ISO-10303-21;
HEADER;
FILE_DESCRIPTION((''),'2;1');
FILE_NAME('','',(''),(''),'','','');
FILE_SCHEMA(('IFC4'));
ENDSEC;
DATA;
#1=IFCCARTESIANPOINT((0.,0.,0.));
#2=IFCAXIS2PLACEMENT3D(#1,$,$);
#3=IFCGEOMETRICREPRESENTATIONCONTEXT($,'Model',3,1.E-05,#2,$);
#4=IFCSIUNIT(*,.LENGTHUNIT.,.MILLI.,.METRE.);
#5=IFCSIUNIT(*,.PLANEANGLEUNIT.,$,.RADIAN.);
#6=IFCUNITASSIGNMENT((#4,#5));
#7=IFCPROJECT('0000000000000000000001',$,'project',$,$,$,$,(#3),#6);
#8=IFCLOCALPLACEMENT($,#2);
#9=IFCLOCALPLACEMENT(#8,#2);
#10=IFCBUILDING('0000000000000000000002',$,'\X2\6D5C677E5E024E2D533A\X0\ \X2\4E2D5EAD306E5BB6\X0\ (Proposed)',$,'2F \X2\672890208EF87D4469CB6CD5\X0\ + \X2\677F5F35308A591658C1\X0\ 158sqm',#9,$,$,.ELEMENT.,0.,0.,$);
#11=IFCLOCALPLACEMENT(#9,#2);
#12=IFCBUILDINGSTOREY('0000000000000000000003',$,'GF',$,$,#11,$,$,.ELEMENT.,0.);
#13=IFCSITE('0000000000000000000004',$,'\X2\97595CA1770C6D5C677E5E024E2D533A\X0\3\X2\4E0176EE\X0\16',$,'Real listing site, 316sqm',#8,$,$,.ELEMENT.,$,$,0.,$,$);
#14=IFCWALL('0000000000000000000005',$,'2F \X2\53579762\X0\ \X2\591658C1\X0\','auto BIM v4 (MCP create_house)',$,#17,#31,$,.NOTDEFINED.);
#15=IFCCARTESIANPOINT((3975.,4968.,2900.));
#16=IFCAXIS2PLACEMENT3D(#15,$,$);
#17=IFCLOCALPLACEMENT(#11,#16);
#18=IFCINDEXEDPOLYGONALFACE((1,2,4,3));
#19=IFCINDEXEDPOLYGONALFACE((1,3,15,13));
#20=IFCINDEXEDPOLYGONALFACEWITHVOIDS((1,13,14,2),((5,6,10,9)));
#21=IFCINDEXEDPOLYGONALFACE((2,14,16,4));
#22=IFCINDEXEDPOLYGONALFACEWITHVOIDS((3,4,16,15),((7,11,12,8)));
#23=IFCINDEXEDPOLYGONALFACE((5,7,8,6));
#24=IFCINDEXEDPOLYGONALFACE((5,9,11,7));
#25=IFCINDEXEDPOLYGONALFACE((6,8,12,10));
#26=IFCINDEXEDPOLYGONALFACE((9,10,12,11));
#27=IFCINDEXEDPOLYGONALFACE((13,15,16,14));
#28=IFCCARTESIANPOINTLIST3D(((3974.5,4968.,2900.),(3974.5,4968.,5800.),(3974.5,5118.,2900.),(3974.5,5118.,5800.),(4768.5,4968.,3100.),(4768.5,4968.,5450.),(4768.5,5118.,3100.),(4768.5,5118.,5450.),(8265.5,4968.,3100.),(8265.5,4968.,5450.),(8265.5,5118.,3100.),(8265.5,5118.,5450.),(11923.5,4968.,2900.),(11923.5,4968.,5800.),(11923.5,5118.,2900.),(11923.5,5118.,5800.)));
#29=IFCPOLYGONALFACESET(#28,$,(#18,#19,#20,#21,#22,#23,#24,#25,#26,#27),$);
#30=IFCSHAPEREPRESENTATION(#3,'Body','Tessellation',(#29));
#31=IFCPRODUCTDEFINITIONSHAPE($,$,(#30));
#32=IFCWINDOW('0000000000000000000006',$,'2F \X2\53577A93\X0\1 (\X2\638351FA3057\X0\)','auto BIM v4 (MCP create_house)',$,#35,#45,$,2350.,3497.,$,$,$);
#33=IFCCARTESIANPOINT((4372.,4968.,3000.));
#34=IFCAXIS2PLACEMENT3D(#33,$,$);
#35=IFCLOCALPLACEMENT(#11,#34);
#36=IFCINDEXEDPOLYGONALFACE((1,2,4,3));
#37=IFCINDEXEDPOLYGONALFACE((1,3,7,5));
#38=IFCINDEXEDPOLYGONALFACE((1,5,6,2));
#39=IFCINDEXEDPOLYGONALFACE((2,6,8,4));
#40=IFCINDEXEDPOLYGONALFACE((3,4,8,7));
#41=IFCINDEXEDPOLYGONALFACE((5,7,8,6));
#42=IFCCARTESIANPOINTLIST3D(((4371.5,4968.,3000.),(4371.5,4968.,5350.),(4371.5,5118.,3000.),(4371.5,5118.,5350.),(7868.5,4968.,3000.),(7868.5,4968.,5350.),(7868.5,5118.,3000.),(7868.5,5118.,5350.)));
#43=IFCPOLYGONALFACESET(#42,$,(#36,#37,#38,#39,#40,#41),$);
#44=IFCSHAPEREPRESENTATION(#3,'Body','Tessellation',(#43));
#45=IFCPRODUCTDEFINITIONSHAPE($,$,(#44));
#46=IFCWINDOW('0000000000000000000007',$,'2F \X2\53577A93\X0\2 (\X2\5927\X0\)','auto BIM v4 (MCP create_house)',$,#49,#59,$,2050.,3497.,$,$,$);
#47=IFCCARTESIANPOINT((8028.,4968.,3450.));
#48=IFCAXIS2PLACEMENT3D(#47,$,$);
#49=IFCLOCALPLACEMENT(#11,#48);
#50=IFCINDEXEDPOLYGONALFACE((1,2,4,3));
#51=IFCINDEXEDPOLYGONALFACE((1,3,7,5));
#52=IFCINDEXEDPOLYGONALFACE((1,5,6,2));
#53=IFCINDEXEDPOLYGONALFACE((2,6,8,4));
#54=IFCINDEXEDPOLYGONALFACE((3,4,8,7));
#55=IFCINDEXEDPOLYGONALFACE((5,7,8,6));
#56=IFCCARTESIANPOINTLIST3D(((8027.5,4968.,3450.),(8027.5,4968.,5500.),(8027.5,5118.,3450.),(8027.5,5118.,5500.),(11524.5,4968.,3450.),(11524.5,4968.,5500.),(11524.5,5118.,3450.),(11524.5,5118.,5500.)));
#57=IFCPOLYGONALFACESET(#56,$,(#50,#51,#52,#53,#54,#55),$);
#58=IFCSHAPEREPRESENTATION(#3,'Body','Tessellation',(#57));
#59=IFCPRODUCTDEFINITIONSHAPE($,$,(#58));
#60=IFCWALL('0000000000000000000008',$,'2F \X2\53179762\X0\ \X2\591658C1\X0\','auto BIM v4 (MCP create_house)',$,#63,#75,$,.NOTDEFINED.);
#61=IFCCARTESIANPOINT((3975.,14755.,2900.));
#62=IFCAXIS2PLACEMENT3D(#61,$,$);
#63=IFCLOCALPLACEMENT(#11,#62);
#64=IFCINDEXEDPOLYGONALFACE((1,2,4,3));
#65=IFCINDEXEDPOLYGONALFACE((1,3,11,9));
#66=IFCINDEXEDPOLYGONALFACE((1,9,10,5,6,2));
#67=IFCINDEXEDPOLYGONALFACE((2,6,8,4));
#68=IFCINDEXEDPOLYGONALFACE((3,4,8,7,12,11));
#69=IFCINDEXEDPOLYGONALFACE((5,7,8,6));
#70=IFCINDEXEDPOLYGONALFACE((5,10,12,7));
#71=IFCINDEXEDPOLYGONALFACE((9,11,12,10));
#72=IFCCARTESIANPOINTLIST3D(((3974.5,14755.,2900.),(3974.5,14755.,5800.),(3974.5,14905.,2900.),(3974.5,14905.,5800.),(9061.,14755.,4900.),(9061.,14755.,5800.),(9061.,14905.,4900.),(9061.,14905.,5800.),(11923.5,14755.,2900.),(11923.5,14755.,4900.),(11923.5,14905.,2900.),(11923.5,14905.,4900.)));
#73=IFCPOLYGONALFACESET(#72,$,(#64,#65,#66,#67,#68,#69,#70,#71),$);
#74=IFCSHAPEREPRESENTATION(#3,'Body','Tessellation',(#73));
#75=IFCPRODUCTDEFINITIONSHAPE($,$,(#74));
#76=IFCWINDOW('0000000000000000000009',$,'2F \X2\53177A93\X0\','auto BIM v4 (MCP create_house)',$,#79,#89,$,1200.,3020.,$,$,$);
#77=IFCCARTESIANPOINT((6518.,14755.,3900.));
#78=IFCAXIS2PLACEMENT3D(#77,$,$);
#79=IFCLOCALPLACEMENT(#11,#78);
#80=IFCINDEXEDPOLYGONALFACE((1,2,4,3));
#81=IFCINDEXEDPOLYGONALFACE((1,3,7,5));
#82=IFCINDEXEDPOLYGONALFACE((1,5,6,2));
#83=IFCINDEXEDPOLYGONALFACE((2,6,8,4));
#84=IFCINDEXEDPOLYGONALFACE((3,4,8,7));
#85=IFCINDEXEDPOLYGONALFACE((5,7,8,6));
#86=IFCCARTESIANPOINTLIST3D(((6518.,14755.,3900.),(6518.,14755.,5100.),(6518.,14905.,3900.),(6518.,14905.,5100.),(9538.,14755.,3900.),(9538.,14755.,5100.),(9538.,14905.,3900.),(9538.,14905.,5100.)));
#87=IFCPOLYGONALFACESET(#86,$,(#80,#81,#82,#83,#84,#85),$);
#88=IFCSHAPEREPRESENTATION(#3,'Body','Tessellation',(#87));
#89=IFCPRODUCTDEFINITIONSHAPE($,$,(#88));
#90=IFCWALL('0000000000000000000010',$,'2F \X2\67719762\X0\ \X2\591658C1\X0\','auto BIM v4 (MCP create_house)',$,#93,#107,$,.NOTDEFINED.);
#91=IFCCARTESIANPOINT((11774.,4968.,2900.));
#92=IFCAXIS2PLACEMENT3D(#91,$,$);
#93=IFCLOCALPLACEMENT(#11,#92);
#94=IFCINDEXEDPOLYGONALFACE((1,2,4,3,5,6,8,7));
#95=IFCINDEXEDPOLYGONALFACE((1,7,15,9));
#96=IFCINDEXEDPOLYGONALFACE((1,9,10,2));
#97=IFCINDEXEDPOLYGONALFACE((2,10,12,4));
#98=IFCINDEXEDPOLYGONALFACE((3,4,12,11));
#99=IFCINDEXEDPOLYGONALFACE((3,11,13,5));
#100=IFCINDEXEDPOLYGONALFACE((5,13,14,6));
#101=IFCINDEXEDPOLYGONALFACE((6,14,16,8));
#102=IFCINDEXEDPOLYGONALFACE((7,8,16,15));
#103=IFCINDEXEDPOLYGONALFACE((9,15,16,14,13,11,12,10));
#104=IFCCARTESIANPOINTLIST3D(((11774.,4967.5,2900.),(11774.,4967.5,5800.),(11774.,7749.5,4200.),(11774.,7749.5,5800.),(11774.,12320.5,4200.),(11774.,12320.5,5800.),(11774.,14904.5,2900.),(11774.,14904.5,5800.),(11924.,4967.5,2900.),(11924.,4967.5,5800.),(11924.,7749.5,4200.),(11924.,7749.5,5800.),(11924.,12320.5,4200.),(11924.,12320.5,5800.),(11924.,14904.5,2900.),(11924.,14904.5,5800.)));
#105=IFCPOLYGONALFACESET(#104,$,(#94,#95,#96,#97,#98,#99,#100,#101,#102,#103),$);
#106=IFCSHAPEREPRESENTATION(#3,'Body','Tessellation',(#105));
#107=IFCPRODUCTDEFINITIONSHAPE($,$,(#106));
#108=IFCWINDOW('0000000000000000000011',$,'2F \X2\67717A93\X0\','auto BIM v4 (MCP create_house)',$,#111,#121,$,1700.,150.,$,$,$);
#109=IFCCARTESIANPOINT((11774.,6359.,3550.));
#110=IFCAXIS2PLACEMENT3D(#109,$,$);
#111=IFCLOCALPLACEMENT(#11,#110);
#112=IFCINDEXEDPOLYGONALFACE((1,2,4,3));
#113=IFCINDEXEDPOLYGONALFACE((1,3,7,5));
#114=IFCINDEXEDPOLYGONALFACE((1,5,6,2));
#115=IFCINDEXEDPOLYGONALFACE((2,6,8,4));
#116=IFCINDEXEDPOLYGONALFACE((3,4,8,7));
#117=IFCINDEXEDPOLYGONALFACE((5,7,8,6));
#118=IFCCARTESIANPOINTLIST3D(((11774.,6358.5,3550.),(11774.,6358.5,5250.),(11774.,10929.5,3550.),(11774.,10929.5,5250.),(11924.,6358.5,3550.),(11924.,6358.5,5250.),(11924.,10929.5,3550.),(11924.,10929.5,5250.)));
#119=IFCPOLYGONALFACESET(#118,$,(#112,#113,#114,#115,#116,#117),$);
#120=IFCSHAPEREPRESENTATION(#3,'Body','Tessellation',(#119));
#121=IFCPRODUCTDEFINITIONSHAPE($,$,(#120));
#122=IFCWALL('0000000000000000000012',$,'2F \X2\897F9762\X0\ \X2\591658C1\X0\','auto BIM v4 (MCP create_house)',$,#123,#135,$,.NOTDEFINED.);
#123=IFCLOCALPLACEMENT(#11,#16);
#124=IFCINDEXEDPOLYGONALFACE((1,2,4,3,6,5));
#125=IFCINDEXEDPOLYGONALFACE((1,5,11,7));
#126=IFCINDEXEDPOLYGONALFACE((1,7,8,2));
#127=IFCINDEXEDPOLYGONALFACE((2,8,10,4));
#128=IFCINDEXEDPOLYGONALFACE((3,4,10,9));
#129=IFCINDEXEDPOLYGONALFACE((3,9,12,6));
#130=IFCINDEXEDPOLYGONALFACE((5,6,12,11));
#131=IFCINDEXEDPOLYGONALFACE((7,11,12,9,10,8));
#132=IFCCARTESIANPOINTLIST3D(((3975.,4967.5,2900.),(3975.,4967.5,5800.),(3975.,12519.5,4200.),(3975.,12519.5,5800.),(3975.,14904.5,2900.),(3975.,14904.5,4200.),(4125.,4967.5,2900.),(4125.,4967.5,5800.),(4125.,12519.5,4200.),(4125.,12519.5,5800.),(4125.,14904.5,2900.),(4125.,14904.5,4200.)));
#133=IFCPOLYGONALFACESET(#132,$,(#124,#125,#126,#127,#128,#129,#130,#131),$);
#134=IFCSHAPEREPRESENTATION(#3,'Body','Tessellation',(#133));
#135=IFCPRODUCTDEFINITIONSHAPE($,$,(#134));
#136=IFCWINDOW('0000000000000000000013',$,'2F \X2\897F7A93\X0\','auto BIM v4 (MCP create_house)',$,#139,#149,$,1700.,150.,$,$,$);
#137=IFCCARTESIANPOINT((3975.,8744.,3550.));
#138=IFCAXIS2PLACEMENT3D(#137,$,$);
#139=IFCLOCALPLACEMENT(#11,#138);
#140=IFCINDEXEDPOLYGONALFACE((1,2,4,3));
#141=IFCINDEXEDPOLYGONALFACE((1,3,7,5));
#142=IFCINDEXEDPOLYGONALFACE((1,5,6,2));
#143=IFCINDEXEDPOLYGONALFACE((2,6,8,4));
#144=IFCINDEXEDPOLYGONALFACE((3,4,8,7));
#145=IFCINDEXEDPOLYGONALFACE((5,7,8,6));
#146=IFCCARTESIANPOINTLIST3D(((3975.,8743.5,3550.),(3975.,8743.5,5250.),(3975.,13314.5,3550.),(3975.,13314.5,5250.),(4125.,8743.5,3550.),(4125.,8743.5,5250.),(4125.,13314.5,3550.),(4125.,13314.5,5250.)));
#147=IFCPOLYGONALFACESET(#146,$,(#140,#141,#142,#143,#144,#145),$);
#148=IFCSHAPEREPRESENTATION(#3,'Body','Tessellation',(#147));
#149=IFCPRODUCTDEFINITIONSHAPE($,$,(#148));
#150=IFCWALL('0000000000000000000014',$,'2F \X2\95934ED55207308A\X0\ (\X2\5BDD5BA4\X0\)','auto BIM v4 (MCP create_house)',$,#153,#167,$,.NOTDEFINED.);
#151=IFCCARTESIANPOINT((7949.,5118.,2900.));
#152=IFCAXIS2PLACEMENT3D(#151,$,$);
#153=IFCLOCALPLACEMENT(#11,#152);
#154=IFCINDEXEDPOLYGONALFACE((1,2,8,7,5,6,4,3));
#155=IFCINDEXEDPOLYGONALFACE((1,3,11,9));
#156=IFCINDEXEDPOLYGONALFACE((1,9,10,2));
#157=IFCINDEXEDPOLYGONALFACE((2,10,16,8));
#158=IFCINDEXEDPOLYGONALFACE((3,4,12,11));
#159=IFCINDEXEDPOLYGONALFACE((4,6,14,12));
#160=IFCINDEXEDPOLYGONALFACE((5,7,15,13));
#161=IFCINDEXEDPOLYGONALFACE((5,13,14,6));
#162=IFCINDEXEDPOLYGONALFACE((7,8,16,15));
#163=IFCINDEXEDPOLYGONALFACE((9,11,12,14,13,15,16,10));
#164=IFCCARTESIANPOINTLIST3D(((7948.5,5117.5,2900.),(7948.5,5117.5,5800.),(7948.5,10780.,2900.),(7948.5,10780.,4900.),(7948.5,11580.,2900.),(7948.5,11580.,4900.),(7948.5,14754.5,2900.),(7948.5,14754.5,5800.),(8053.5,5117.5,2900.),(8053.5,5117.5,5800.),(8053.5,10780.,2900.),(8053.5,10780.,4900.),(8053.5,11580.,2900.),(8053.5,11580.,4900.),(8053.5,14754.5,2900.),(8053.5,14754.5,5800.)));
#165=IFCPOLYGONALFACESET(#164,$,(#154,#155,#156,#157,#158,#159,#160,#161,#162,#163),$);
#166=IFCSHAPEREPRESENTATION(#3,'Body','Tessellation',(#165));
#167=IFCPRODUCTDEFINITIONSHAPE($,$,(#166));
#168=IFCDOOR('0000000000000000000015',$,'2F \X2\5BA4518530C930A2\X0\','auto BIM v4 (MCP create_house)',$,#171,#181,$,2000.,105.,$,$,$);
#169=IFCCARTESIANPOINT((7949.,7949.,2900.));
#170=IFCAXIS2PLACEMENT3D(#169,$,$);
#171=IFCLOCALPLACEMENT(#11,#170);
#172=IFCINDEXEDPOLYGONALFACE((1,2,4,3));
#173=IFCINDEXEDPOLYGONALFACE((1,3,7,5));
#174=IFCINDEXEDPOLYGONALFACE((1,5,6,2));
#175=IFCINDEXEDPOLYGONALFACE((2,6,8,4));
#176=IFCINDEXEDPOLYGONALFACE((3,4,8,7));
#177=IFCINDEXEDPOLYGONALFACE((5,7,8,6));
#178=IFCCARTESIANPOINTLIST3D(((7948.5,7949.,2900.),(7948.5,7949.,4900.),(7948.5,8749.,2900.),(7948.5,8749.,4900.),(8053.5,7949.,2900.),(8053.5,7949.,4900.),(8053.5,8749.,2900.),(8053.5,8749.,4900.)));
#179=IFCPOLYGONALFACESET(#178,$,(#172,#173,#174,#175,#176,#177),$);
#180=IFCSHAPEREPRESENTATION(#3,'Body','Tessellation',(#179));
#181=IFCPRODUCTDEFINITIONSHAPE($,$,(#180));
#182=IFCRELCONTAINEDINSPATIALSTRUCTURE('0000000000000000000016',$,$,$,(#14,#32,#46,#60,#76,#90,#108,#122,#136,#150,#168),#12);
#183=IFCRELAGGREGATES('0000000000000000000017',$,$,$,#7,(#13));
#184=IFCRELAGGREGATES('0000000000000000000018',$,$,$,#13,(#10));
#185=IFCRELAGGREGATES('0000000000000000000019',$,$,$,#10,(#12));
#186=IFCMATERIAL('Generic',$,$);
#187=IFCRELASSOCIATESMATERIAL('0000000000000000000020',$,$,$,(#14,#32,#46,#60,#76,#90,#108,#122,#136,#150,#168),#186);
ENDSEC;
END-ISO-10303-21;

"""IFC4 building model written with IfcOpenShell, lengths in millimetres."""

from ifc_helpers import new_model, si_unit, frame, frame_2d, origin, place, context, project, spatial, rectangle, extrude, material, element, fill, save


model = new_model("IFC4")

# Units and contexts
model_context = context("Model", 3, precision=1e-05, world=origin())
ifc_project = project(units=[si_unit("LENGTHUNIT", "METRE", prefix="MILLI"), si_unit("PLANEANGLEUNIT", "RADIAN")], contexts=[model_context])

# Site, building, storey
site_placement = place(None, origin())
site = spatial("IfcSite", under=ifc_project, at=site_placement, Name="静岡県浜松市中区3丁目16", ObjectType="Real listing site, 316sqm", CompositionType="ELEMENT", RefElevation=0.0)
building_placement = place(site_placement, origin())
building = spatial("IfcBuilding", under=site, at=building_placement, Name="浜松市中区 中庭の家 (Proposed)", ObjectType="2F 木造軸組構法 + 板張り外壁 158sqm", CompositionType="ELEMENT", ElevationOfRefHeight=0.0, ElevationOfTerrain=0.0)
storey_placement = place(building_placement, origin())
storey = spatial("IfcBuildingStorey", under=building, at=storey_placement, Name="GF", CompositionType="ELEMENT", Elevation=0.0)

# Shared definitions
ifc_material = material(Name="Generic")

# Wall, openings, windows
wall_1_placement = place(storey_placement, frame((3975.0, 4968.0, 2900.0)))
wall_1 = element("IfcWall", 1, at=wall_1_placement, inside=storey, material=ifc_material, Name="2F 南面 外壁", Description="auto BIM v4 (MCP create_house)", PredefinedType="NOTDEFINED", context=model_context, shape_type="SweptSolid", body=[
    extrude(rectangle(XDim=7949.0, YDim=150.0, at=frame_2d((3974.0, 75.0))), frame((3975.0, 4968.0, 2900.0)), (0.0, 0.0, 1.0), 2900.0),
])
opening_1_placement = place(storey_placement, frame((4372.0, 4968.0, 3000.0)))
opening_1 = element("IfcOpeningElement", 2, at=opening_1_placement, cuts=wall_1, PredefinedType="NOTDEFINED", context=model_context, shape_type="SweptSolid", body=[
    extrude(rectangle(XDim=3497.0, YDim=150.0, at=frame_2d((1748.0, 75.0))), frame((4372.0, 4968.0, 3000.0)), (0.0, 0.0, 1.0), 2350.0),
])
opening_2_placement = place(storey_placement, frame((8028.0, 4968.0, 3450.0)))
opening_2 = element("IfcOpeningElement", 3, at=opening_2_placement, cuts=wall_1, PredefinedType="NOTDEFINED", context=model_context, shape_type="SweptSolid", body=[
    extrude(rectangle(XDim=3497.0, YDim=150.0, at=frame_2d((1748.0, 75.0))), frame((8028.0, 4968.0, 3450.0)), (0.0, 0.0, 1.0), 2050.0),
])
window_1_placement = place(storey_placement, frame((4372.0, 4968.0, 3000.0)))
window_1 = element("IfcWindow", 4, at=window_1_placement, inside=storey, material=ifc_material, Name="2F 南窓1 (掃出し)", Description="auto BIM v4 (MCP create_house)", OverallHeight=2350.0, OverallWidth=3497.0, context=model_context, shape_type="SweptSolid", body=[
    extrude(rectangle(XDim=3497.0, YDim=150.0, at=frame_2d((1748.0, 75.0))), frame((4372.0, 4968.0, 3000.0)), (0.0, 0.0, 1.0), 2350.0),
])
fill(opening_1, window_1)
window_2_placement = place(storey_placement, frame((8028.0, 4968.0, 3450.0)))
window_2 = element("IfcWindow", 5, at=window_2_placement, inside=storey, material=ifc_material, Name="2F 南窓2 (大)", Description="auto BIM v4 (MCP create_house)", OverallHeight=2050.0, OverallWidth=3497.0, context=model_context, shape_type="SweptSolid", body=[
    extrude(rectangle(XDim=3497.0, YDim=150.0, at=frame_2d((1748.0, 75.0))), frame((8028.0, 4968.0, 3450.0)), (0.0, 0.0, 1.0), 2050.0),
])
fill(opening_2, window_2)

# Walls, openings, windows
wall_2_placement = place(storey_placement, frame((3975.0, 14755.0, 2900.0)))
wall_2 = element("IfcWall", 6, at=wall_2_placement, inside=storey, material=ifc_material, Name="2F 北面 外壁", Description="auto BIM v4 (MCP create_house)", PredefinedType="NOTDEFINED", context=model_context, shape_type="SweptSolid", body=[
    extrude(rectangle(XDim=7949.0, YDim=150.0, at=frame_2d((3974.0, 75.0))), frame((3975.0, 14755.0, 2900.0)), (0.0, 0.0, 1.0), 2900.0),
])
opening_3_placement = place(storey_placement, frame((6518.0, 14755.0, 3900.0)))
opening_3 = element("IfcOpeningElement", 7, at=opening_3_placement, cuts=wall_2, PredefinedType="NOTDEFINED", context=model_context, shape_type="SweptSolid", body=[
    extrude(rectangle(XDim=3020.0, YDim=150.0, at=frame_2d((1510.0, 75.0))), frame((6518.0, 14755.0, 3900.0)), (0.0, 0.0, 1.0), 1200.0),
])
window_3_placement = place(storey_placement, frame((6518.0, 14755.0, 3900.0)))
window_3 = element("IfcWindow", 8, at=window_3_placement, inside=storey, material=ifc_material, Name="2F 北窓", Description="auto BIM v4 (MCP create_house)", OverallHeight=1200.0, OverallWidth=3020.0, context=model_context, shape_type="SweptSolid", body=[
    extrude(rectangle(XDim=3020.0, YDim=150.0, at=frame_2d((1510.0, 75.0))), frame((6518.0, 14755.0, 3900.0)), (0.0, 0.0, 1.0), 1200.0),
])
fill(opening_3, window_3)
wall_3_placement = place(storey_placement, frame((11774.0, 4968.0, 2900.0)))
wall_3 = element("IfcWall", 9, at=wall_3_placement, inside=storey, material=ifc_material, Name="2F 東面 外壁", Description="auto BIM v4 (MCP create_house)", PredefinedType="NOTDEFINED", context=model_context, shape_type="SweptSolid", body=[
    extrude(rectangle(XDim=150.0, YDim=9937.0, at=frame_2d((75.0, 4968.0))), frame((11774.0, 4968.0, 2900.0)), (0.0, 0.0, 1.0), 2900.0),
])
opening_4_placement = place(storey_placement, frame((11774.0, 6359.0, 3550.0)))
opening_4 = element("IfcOpeningElement", 10, at=opening_4_placement, cuts=wall_3, PredefinedType="NOTDEFINED", context=model_context, shape_type="SweptSolid", body=[
    extrude(rectangle(XDim=150.0, YDim=4571.0, at=frame_2d((75.0, 2285.0))), frame((11774.0, 6359.0, 3550.0)), (0.0, 0.0, 1.0), 1700.0),
])
window_4_placement = place(storey_placement, frame((11774.0, 6359.0, 3550.0)))
window_4 = element("IfcWindow", 11, at=window_4_placement, inside=storey, material=ifc_material, Name="2F 東窓", Description="auto BIM v4 (MCP create_house)", OverallHeight=1700.0, OverallWidth=150.0, context=model_context, shape_type="SweptSolid", body=[
    extrude(rectangle(XDim=150.0, YDim=4571.0, at=frame_2d((75.0, 2285.0))), frame((11774.0, 6359.0, 3550.0)), (0.0, 0.0, 1.0), 1700.0),
])
fill(opening_4, window_4)
wall_4_placement = place(storey_placement, frame((3975.0, 4968.0, 2900.0)))
wall_4 = element("IfcWall", 12, at=wall_4_placement, inside=storey, material=ifc_material, Name="2F 西面 外壁", Description="auto BIM v4 (MCP create_house)", PredefinedType="NOTDEFINED", context=model_context, shape_type="SweptSolid", body=[
    extrude(rectangle(XDim=150.0, YDim=9937.0, at=frame_2d((75.0, 4968.0))), frame((3975.0, 4968.0, 2900.0)), (0.0, 0.0, 1.0), 2900.0),
])
opening_5_placement = place(storey_placement, frame((3975.0, 8744.0, 3550.0)))
opening_5 = element("IfcOpeningElement", 13, at=opening_5_placement, cuts=wall_4, PredefinedType="NOTDEFINED", context=model_context, shape_type="SweptSolid", body=[
    extrude(rectangle(XDim=150.0, YDim=4571.0, at=frame_2d((75.0, 2285.0))), frame((3975.0, 8744.0, 3550.0)), (0.0, 0.0, 1.0), 1700.0),
])
window_5_placement = place(storey_placement, frame((3975.0, 8744.0, 3550.0)))
window_5 = element("IfcWindow", 14, at=window_5_placement, inside=storey, material=ifc_material, Name="2F 西窓", Description="auto BIM v4 (MCP create_house)", OverallHeight=1700.0, OverallWidth=150.0, context=model_context, shape_type="SweptSolid", body=[
    extrude(rectangle(XDim=150.0, YDim=4571.0, at=frame_2d((75.0, 2285.0))), frame((3975.0, 8744.0, 3550.0)), (0.0, 0.0, 1.0), 1700.0),
])
fill(opening_5, window_5)

# Wall, opening, door
wall_5_placement = place(storey_placement, frame((7949.0, 5118.0, 2900.0)))
wall_5 = element("IfcWall", 15, at=wall_5_placement, inside=storey, material=ifc_material, Name="2F 間仕切り (寝室)", Description="auto BIM v4 (MCP create_house)", PredefinedType="NOTDEFINED", context=model_context, shape_type="SweptSolid", body=[
    extrude(rectangle(XDim=105.0, YDim=9637.0, at=frame_2d((52.0, 4818.0))), frame((7949.0, 5118.0, 2900.0)), (0.0, 0.0, 1.0), 2900.0),
])
opening_6_placement = place(storey_placement, frame((7949.0, 7949.0, 2900.0)))
opening_6 = element("IfcOpeningElement", 16, at=opening_6_placement, cuts=wall_5, PredefinedType="NOTDEFINED", context=model_context, shape_type="SweptSolid", body=[
    extrude(rectangle(XDim=105.0, YDim=800.0, at=frame_2d((52.0, 400.0))), frame((7949.0, 7949.0, 2900.0)), (0.0, 0.0, 1.0), 2000.0),
])
door_1_placement = place(storey_placement, frame((7949.0, 7949.0, 2900.0)))
door_1 = element("IfcDoor", 17, at=door_1_placement, inside=storey, material=ifc_material, Name="2F 室内ドア", Description="auto BIM v4 (MCP create_house)", OverallHeight=2000.0, OverallWidth=105.0, context=model_context, shape_type="SweptSolid", body=[
    extrude(rectangle(XDim=105.0, YDim=800.0, at=frame_2d((52.0, 400.0))), frame((7949.0, 7949.0, 2900.0)), (0.0, 0.0, 1.0), 2000.0),
])
fill(opening_6, door_1)

save(model, "model.ifc")
